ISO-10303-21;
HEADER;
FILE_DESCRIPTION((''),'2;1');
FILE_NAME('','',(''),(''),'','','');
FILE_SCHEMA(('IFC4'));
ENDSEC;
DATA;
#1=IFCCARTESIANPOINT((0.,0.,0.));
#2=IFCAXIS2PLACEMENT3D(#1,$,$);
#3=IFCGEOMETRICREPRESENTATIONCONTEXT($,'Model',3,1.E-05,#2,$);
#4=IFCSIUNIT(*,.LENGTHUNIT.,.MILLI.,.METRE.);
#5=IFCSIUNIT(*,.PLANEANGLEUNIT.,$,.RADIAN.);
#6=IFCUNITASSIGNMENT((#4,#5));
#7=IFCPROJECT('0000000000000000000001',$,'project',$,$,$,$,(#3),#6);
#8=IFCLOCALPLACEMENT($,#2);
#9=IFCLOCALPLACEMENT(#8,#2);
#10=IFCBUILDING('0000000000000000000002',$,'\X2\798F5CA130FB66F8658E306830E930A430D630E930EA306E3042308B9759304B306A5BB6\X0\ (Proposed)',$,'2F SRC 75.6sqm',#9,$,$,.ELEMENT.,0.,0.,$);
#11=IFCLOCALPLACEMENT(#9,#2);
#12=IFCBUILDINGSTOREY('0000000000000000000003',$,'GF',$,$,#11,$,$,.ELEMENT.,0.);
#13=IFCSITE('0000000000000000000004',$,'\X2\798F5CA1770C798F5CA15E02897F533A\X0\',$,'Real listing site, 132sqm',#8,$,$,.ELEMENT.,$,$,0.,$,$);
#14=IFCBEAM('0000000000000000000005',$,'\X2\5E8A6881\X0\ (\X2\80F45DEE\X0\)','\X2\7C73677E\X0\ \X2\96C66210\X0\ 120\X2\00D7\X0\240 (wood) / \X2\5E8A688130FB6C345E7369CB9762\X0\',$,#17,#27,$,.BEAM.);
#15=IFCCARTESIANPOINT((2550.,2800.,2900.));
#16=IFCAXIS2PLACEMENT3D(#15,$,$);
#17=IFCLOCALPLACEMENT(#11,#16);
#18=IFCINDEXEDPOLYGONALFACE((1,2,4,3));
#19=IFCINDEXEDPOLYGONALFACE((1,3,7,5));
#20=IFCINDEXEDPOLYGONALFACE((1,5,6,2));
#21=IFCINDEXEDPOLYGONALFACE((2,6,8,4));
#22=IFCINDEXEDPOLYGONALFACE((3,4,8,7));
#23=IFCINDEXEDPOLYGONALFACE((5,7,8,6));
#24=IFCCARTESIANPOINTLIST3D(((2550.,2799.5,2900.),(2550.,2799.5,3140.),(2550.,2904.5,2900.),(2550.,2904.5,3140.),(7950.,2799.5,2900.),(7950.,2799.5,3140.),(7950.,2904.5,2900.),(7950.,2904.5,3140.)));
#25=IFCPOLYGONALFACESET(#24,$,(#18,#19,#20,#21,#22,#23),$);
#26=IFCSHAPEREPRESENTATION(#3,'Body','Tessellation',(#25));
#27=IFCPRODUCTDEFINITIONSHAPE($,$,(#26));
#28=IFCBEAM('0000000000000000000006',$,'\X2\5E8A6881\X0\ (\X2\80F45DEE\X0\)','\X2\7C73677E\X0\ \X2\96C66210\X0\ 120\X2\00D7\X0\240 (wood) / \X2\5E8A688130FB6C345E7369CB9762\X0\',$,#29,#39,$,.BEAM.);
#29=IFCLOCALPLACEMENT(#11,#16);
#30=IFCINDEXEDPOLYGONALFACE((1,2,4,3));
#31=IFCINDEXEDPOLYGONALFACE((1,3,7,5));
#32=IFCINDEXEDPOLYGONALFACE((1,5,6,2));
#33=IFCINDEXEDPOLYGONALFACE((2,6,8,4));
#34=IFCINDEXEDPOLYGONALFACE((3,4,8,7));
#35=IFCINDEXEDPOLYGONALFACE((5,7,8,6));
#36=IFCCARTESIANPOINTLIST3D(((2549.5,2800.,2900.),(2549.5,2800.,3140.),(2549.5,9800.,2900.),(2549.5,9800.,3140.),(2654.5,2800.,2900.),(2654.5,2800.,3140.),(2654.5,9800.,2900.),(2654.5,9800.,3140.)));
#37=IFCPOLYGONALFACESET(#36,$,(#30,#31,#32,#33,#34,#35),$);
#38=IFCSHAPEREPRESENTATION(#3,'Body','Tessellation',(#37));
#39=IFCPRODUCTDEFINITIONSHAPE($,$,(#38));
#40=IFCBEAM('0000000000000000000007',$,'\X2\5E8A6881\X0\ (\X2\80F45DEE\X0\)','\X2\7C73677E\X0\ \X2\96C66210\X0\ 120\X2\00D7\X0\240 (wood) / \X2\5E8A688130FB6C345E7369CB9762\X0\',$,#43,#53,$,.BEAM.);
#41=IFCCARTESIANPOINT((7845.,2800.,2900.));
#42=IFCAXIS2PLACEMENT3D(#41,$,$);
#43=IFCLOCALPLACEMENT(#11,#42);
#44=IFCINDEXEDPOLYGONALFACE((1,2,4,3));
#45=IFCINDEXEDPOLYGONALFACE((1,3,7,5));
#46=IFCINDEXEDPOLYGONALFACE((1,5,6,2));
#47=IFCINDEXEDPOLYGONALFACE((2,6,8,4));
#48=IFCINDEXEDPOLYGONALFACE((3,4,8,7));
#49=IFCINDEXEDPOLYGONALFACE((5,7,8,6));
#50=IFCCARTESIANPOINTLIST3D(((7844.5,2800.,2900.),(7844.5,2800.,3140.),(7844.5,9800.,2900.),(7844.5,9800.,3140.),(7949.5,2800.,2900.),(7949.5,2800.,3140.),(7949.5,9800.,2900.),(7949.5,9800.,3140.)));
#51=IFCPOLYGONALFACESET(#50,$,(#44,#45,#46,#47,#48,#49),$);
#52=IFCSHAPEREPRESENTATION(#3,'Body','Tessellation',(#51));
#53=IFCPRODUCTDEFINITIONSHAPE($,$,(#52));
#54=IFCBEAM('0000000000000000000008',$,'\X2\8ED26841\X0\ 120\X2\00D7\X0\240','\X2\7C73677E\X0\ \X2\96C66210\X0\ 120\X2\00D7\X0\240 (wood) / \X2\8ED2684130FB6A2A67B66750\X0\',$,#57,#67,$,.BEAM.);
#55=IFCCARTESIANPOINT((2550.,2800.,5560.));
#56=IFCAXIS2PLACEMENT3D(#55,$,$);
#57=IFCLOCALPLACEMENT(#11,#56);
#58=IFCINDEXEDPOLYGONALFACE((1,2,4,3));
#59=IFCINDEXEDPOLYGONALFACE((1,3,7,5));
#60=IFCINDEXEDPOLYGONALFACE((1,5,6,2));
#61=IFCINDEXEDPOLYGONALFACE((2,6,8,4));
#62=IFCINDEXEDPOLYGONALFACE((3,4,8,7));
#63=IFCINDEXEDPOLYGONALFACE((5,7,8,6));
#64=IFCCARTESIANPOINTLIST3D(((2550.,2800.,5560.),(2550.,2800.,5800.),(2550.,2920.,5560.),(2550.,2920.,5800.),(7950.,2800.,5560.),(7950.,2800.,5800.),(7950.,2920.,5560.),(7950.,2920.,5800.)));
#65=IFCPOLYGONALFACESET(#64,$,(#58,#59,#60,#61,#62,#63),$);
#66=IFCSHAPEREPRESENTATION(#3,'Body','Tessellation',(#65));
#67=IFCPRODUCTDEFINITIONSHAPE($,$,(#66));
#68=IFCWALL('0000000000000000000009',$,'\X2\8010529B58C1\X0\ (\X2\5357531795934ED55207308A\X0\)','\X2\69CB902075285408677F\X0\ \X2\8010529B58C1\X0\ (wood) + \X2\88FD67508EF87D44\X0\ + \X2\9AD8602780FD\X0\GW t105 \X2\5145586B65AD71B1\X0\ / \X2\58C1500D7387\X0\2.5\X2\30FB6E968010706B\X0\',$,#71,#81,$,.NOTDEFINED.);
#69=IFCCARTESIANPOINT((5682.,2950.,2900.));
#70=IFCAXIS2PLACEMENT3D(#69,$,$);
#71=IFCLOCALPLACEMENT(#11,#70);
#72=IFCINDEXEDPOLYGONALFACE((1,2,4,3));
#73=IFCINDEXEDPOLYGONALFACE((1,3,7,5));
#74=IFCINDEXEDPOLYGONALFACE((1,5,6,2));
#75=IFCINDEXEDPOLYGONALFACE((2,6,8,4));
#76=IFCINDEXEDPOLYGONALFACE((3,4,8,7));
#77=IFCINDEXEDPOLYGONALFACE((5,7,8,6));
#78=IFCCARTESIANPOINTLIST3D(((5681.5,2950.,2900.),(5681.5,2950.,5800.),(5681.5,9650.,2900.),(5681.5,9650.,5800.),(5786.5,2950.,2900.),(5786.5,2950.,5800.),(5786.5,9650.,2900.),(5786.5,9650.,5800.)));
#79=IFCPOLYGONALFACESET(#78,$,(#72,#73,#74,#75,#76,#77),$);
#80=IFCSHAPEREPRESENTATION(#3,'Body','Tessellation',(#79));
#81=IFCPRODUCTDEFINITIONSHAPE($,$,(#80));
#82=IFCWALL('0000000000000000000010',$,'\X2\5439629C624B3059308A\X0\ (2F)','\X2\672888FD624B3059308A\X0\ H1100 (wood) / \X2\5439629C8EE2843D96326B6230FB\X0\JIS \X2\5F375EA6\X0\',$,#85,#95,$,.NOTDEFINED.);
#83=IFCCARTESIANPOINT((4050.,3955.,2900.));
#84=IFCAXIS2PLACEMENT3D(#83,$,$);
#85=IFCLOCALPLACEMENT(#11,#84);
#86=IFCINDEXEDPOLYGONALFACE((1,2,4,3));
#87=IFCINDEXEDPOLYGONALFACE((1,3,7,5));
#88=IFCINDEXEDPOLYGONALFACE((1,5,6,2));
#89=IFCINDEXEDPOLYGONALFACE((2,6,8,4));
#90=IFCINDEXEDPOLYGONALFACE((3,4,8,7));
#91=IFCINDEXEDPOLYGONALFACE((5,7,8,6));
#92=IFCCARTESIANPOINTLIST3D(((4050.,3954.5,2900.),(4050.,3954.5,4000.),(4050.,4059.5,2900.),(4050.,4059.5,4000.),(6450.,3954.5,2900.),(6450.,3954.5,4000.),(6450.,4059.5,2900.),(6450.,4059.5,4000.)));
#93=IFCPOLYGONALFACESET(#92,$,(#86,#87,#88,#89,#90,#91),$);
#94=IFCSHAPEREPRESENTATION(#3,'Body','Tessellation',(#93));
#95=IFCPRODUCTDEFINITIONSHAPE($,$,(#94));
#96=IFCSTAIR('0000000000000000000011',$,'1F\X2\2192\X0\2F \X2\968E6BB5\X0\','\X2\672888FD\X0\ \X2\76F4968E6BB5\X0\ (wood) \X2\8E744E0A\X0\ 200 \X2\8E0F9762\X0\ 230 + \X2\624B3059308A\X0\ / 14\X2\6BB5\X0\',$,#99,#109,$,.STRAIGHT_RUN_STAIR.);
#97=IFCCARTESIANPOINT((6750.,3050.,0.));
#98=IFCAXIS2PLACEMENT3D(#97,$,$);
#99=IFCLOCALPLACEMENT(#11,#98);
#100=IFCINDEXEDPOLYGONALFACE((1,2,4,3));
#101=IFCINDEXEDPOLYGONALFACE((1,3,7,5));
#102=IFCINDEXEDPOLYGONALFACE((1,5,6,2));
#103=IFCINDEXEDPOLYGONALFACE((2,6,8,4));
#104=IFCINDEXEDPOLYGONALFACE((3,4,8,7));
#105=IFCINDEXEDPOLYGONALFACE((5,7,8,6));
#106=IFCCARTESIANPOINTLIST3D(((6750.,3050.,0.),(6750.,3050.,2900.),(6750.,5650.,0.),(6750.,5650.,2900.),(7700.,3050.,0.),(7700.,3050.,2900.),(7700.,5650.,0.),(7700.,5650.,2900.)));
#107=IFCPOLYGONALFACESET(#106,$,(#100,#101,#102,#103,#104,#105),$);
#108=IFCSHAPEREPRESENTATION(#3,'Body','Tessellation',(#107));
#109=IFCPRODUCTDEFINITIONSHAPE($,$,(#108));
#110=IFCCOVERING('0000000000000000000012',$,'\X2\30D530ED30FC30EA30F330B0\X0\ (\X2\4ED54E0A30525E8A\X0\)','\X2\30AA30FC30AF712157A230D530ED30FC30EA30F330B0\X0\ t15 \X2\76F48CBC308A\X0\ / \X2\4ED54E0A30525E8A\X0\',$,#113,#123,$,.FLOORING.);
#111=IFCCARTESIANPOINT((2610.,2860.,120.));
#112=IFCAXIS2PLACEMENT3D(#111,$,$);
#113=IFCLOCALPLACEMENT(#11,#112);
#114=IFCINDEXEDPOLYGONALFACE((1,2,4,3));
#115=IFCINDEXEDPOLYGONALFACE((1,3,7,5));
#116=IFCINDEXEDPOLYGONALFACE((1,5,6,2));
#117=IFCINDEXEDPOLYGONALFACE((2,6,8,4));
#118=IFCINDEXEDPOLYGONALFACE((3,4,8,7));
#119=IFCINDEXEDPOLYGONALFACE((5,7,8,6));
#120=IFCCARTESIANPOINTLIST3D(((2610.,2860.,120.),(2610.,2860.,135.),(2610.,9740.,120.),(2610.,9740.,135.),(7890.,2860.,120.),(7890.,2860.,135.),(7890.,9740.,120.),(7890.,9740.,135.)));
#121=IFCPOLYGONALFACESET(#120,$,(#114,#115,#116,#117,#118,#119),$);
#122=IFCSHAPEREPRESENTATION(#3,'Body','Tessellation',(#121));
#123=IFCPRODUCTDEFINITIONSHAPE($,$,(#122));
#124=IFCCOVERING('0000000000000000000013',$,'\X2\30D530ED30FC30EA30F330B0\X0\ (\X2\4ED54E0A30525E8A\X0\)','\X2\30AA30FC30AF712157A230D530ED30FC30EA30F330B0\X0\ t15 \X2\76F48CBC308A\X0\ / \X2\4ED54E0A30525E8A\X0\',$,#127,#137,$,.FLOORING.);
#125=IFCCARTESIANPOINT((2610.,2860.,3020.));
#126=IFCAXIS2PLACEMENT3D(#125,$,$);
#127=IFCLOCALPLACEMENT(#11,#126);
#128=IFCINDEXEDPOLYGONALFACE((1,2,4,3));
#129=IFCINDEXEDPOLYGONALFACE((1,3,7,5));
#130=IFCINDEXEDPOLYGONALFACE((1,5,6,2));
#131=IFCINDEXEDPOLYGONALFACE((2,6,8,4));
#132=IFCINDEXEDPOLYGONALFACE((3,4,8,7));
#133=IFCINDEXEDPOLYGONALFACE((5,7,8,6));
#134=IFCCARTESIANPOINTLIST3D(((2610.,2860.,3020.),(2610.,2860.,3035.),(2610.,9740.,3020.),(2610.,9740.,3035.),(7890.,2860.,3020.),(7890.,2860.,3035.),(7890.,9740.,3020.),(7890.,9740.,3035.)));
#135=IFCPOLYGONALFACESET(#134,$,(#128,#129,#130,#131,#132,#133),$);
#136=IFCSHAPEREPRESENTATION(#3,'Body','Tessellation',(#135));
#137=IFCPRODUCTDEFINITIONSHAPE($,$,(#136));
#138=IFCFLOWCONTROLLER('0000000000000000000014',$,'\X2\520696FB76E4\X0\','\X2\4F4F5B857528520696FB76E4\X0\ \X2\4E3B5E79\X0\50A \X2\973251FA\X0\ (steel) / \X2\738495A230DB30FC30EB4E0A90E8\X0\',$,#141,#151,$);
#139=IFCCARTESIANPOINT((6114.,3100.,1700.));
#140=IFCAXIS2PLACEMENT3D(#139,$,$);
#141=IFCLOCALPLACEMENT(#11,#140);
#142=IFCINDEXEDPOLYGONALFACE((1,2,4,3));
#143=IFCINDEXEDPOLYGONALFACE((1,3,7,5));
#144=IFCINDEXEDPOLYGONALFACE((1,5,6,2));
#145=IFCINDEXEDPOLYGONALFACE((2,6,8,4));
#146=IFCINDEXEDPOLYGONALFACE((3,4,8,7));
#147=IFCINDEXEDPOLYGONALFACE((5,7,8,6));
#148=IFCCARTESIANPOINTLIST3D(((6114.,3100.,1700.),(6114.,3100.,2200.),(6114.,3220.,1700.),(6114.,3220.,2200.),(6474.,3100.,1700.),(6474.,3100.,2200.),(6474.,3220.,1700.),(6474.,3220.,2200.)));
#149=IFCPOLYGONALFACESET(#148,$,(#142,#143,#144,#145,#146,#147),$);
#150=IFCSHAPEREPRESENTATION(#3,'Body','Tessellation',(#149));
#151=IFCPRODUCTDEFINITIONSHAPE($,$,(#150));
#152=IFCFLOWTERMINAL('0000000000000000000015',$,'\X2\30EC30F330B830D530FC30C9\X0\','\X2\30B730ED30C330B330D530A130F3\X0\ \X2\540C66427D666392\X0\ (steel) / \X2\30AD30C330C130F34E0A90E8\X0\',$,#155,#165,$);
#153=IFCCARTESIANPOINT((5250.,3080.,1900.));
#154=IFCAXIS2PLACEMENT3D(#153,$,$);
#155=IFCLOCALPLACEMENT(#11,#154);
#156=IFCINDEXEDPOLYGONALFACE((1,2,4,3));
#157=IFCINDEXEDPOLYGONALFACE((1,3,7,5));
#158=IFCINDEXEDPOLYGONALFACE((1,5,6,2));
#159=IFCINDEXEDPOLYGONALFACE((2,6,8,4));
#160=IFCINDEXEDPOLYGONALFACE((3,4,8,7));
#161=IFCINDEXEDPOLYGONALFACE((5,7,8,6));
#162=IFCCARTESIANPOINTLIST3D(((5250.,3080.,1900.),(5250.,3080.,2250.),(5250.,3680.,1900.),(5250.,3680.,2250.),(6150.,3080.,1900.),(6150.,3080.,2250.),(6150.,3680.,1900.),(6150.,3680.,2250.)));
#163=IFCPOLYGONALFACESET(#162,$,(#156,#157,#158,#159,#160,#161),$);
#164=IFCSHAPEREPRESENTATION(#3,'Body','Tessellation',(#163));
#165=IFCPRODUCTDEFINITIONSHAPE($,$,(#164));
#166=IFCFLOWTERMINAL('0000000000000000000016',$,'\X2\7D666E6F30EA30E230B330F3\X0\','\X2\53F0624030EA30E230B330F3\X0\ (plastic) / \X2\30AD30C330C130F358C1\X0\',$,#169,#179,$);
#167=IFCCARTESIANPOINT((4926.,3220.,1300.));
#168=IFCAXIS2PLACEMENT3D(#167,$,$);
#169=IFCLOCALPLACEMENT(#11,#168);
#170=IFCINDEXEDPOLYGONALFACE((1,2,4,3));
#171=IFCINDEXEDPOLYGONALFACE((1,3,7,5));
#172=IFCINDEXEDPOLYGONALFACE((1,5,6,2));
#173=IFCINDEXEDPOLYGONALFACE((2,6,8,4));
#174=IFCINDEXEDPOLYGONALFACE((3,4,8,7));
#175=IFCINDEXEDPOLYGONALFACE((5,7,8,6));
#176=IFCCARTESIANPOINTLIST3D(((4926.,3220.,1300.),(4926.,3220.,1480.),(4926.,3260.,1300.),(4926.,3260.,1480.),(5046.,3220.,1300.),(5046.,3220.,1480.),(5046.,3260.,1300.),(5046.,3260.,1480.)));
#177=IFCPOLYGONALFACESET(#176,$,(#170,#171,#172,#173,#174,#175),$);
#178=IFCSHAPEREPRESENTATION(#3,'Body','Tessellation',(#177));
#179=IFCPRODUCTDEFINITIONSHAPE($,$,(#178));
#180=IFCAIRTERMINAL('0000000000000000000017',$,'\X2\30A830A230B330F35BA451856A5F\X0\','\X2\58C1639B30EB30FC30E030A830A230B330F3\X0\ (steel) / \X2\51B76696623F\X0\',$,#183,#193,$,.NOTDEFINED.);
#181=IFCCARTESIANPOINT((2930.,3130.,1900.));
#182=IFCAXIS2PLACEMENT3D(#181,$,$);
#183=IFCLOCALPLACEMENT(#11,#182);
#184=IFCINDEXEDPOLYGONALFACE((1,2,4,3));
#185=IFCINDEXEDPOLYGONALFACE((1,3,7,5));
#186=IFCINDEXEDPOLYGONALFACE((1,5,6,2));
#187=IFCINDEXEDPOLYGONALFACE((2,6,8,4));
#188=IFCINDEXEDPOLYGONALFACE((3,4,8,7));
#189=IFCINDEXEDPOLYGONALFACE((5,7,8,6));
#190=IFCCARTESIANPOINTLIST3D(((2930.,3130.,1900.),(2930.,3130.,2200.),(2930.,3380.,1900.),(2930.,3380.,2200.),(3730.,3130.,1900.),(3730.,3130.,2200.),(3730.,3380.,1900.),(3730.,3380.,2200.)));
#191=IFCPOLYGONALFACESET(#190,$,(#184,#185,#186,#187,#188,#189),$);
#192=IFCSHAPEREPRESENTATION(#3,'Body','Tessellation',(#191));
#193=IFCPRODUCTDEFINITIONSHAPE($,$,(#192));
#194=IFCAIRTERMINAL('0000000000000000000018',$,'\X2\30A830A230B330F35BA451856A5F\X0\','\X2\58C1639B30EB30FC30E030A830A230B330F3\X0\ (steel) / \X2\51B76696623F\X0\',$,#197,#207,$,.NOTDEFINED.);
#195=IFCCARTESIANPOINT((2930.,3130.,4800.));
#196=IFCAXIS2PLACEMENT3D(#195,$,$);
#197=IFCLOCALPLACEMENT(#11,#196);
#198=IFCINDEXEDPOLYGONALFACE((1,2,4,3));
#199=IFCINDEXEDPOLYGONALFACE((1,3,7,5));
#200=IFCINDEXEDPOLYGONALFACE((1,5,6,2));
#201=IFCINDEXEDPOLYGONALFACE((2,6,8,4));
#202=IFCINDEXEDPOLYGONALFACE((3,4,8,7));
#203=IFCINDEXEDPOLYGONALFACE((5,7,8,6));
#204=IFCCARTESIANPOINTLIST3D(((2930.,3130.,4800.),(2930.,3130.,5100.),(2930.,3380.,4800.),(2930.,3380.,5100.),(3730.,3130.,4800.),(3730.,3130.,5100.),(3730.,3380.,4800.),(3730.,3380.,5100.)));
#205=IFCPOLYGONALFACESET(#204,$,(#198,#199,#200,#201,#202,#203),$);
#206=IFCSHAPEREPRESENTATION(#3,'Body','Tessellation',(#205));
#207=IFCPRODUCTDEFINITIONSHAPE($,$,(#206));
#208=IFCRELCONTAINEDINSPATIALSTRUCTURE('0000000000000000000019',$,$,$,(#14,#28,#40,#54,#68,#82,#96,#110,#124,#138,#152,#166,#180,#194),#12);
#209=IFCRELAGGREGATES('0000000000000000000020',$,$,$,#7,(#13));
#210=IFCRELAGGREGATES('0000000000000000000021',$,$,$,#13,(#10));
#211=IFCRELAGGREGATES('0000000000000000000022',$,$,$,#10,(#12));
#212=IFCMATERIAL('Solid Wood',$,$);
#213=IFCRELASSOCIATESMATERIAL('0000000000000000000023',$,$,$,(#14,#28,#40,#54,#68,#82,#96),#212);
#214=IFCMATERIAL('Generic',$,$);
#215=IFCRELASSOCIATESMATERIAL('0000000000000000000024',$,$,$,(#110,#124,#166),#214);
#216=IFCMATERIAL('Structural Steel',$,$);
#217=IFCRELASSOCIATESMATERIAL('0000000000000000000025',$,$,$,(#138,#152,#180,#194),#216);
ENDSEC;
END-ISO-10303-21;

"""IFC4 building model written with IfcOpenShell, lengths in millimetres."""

from ifc_helpers import new_model, si_unit, frame, frame_2d, origin, place, context, project, spatial, rectangle, extrude, material, element, save


model = new_model("IFC4")

# Units and contexts
model_context = context("Model", 3, precision=1e-05, world=origin())
ifc_project = project(units=[si_unit("LENGTHUNIT", "METRE", prefix="MILLI"), si_unit("PLANEANGLEUNIT", "RADIAN")], contexts=[model_context])

# Site, building, storey
site_placement = place(None, origin())
site = spatial("IfcSite", under=ifc_project, at=site_placement, Name="福岡県福岡市西区", ObjectType="Real listing site, 132sqm", CompositionType="ELEMENT", RefElevation=0.0)
building_placement = place(site_placement, origin())
building = spatial("IfcBuilding", under=site, at=building_placement, Name="福岡・書斎とライブラリのある静かな家 (Proposed)", ObjectType="2F SRC 75.6sqm", CompositionType="ELEMENT", ElevationOfRefHeight=0.0, ElevationOfTerrain=0.0)
storey_placement = place(building_placement, origin())
storey = spatial("IfcBuildingStorey", under=building, at=storey_placement, Name="GF", CompositionType="ELEMENT", Elevation=0.0)

# Beams
ifc_material_1 = material(Name="Solid Wood")
beam_1_placement = place(storey_placement, frame((2550.0, 2800.0, 2900.0)))
element("IfcBeam", 1, at=beam_1_placement, inside=storey, material=ifc_material_1, Name="床梁 (胴差)", Description="米松 集成 120×240 (wood) / 床梁・水平構面", PredefinedType="BEAM", context=model_context, shape_type="SweptSolid", body=[
    extrude(rectangle(XDim=5400.0, YDim=105.0, at=frame_2d((2700.0, 52.0))), frame((2550.0, 2800.0, 2900.0)), (0.0, 0.0, 1.0), 240.0),
])
beam_2_placement = place(storey_placement, frame((2550.0, 2800.0, 2900.0)))
element("IfcBeam", 2, at=beam_2_placement, inside=storey, material=ifc_material_1, Name="床梁 (胴差)", Description="米松 集成 120×240 (wood) / 床梁・水平構面", PredefinedType="BEAM", context=model_context, shape_type="SweptSolid", body=[
    extrude(rectangle(XDim=105.0, YDim=7000.0, at=frame_2d((52.0, 3500.0))), frame((2550.0, 2800.0, 2900.0)), (0.0, 0.0, 1.0), 240.0),
])
beam_3_placement = place(storey_placement, frame((7845.0, 2800.0, 2900.0)))
element("IfcBeam", 3, at=beam_3_placement, inside=storey, material=ifc_material_1, Name="床梁 (胴差)", Description="米松 集成 120×240 (wood) / 床梁・水平構面", PredefinedType="BEAM", context=model_context, shape_type="SweptSolid", body=[
    extrude(rectangle(XDim=105.0, YDim=7000.0, at=frame_2d((52.0, 3500.0))), frame((7845.0, 2800.0, 2900.0)), (0.0, 0.0, 1.0), 240.0),
])
beam_4_placement = place(storey_placement, frame((2550.0, 2800.0, 5560.0)))
element("IfcBeam", 4, at=beam_4_placement, inside=storey, material=ifc_material_1, Name="軒桁 120×240", Description="米松 集成 120×240 (wood) / 軒桁・横架材", PredefinedType="BEAM", context=model_context, shape_type="SweptSolid", body=[
    extrude(rectangle(XDim=5400.0, YDim=120.0, at=frame_2d((2700.0, 60.0))), frame((2550.0, 2800.0, 5560.0)), (0.0, 0.0, 1.0), 240.0),
])

# Walls
wall_1_placement = place(storey_placement, frame((5682.0, 2950.0, 2900.0)))
element("IfcWall", 5, at=wall_1_placement, inside=storey, material=ifc_material_1, Name="耐力壁 (南北間仕切り)", Description="構造用合板 耐力壁 (wood) + 製材軸組 + 高性能GW t105 充填断熱 / 壁倍率2.5・準耐火", PredefinedType="NOTDEFINED", context=model_context, shape_type="SweptSolid", body=[
    extrude(rectangle(XDim=105.0, YDim=6700.0, at=frame_2d((52.0, 3350.0))), frame((5682.0, 2950.0, 2900.0)), (0.0, 0.0, 1.0), 2900.0),
])
wall_2_placement = place(storey_placement, frame((4050.0, 3955.0, 2900.0)))
element("IfcWall", 6, at=wall_2_placement, inside=storey, material=ifc_material_1, Name="吹抜手すり (2F)", Description="木製手すり H1100 (wood) / 吹抜転落防止・JIS 強度", PredefinedType="NOTDEFINED", context=model_context, shape_type="SweptSolid", body=[
    extrude(rectangle(XDim=2400.0, YDim=105.0, at=frame_2d((1200.0, 52.0))), frame((4050.0, 3955.0, 2900.0)), (0.0, 0.0, 1.0), 1100.0),
])

# Stair
stair_placement = place(storey_placement, frame((6750.0, 3050.0, 0.0)))
element("IfcStair", 7, at=stair_placement, inside=storey, material=ifc_material_1, Name="1F→2F 階段", Description="木製 直階段 (wood) 蹴上 200 踏面 230 + 手すり / 14段", PredefinedType="STRAIGHT_RUN_STAIR", context=model_context, shape_type="SweptSolid", body=[
    extrude(rectangle(XDim=950.0, YDim=2600.0, at=frame_2d((475.0, 1300.0))), frame((6750.0, 3050.0, 0.0)), (0.0, 0.0, 1.0), 2900.0),
])

# Coverings
ifc_material_2 = material(Name="Generic")
covering_1_placement = place(storey_placement, frame((2610.0, 2860.0, 120.0)))
element("IfcCovering", 8, at=covering_1_placement, inside=storey, material=ifc_material_2, Name="フローリング (仕上げ床)", Description="オーク無垢フローリング t15 直貼り / 仕上げ床", PredefinedType="FLOORING", context=model_context, shape_type="SweptSolid", body=[
    extrude(rectangle(XDim=5280.0, YDim=6880.0, at=frame_2d((2640.0, 3440.0))), frame((2610.0, 2860.0, 120.0)), (0.0, 0.0, 1.0), 15.0),
])
covering_2_placement = place(storey_placement, frame((2610.0, 2860.0, 3020.0)))
element("IfcCovering", 9, at=covering_2_placement, inside=storey, material=ifc_material_2, Name="フローリング (仕上げ床)", Description="オーク無垢フローリング t15 直貼り / 仕上げ床", PredefinedType="FLOORING", context=model_context, shape_type="SweptSolid", body=[
    extrude(rectangle(XDim=5280.0, YDim=6880.0, at=frame_2d((2640.0, 3440.0))), frame((2610.0, 2860.0, 3020.0)), (0.0, 0.0, 1.0), 15.0),
])

# Flow controller
ifc_material_3 = material(Name="Structural Steel")
flow_controller_placement = place(storey_placement, frame((6114.0, 3100.0, 1700.0)))
element("IfcFlowController", 10, at=flow_controller_placement, inside=storey, material=ifc_material_3, Name="分電盤", Description="住宅用分電盤 主幹50A 露出 (steel) / 玄関ホール上部", context=model_context, shape_type="SweptSolid", body=[
    extrude(rectangle(XDim=360.0, YDim=120.0, at=frame_2d((180.0, 60.0))), frame((6114.0, 3100.0, 1700.0)), (0.0, 0.0, 1.0), 500.0),
])

# Flow terminals
flow_terminal_1_placement = place(storey_placement, frame((5250.0, 3080.0, 1900.0)))
element("IfcFlowTerminal", 11, at=flow_terminal_1_placement, inside=storey, material=ifc_material_3, Name="レンジフード", Description="シロッコファン 同時給排 (steel) / キッチン上部", context=model_context, shape_type="SweptSolid", body=[
    extrude(rectangle(XDim=900.0, YDim=600.0, at=frame_2d((450.0, 300.0))), frame((5250.0, 3080.0, 1900.0)), (0.0, 0.0, 1.0), 350.0),
])
flow_terminal_2_placement = place(storey_placement, frame((4926.0, 3220.0, 1300.0)))
element("IfcFlowTerminal", 12, at=flow_terminal_2_placement, inside=storey, material=ifc_material_2, Name="給湯リモコン", Description="台所リモコン (plastic) / キッチン壁", context=model_context, shape_type="SweptSolid", body=[
    extrude(rectangle(XDim=120.0, YDim=40.0, at=frame_2d((60.0, 20.0))), frame((4926.0, 3220.0, 1300.0)), (0.0, 0.0, 1.0), 180.0),
])

# Air terminals
air_terminal_1_placement = place(storey_placement, frame((2930.0, 3130.0, 1900.0)))
element("IfcAirTerminal", 13, at=air_terminal_1_placement, inside=storey, material=ifc_material_3, Name="エアコン室内機", Description="壁掛ルームエアコン (steel) / 冷暖房", PredefinedType="NOTDEFINED", context=model_context, shape_type="SweptSolid", body=[
    extrude(rectangle(XDim=800.0, YDim=250.0, at=frame_2d((400.0, 125.0))), frame((2930.0, 3130.0, 1900.0)), (0.0, 0.0, 1.0), 300.0),
])
air_terminal_2_placement = place(storey_placement, frame((2930.0, 3130.0, 4800.0)))
element("IfcAirTerminal", 14, at=air_terminal_2_placement, inside=storey, material=ifc_material_3, Name="エアコン室内機", Description="壁掛ルームエアコン (steel) / 冷暖房", PredefinedType="NOTDEFINED", context=model_context, shape_type="SweptSolid", body=[
    extrude(rectangle(XDim=800.0, YDim=250.0, at=frame_2d((400.0, 125.0))), frame((2930.0, 3130.0, 4800.0)), (0.0, 0.0, 1.0), 300.0),
])

save(model, "model.ifc")
